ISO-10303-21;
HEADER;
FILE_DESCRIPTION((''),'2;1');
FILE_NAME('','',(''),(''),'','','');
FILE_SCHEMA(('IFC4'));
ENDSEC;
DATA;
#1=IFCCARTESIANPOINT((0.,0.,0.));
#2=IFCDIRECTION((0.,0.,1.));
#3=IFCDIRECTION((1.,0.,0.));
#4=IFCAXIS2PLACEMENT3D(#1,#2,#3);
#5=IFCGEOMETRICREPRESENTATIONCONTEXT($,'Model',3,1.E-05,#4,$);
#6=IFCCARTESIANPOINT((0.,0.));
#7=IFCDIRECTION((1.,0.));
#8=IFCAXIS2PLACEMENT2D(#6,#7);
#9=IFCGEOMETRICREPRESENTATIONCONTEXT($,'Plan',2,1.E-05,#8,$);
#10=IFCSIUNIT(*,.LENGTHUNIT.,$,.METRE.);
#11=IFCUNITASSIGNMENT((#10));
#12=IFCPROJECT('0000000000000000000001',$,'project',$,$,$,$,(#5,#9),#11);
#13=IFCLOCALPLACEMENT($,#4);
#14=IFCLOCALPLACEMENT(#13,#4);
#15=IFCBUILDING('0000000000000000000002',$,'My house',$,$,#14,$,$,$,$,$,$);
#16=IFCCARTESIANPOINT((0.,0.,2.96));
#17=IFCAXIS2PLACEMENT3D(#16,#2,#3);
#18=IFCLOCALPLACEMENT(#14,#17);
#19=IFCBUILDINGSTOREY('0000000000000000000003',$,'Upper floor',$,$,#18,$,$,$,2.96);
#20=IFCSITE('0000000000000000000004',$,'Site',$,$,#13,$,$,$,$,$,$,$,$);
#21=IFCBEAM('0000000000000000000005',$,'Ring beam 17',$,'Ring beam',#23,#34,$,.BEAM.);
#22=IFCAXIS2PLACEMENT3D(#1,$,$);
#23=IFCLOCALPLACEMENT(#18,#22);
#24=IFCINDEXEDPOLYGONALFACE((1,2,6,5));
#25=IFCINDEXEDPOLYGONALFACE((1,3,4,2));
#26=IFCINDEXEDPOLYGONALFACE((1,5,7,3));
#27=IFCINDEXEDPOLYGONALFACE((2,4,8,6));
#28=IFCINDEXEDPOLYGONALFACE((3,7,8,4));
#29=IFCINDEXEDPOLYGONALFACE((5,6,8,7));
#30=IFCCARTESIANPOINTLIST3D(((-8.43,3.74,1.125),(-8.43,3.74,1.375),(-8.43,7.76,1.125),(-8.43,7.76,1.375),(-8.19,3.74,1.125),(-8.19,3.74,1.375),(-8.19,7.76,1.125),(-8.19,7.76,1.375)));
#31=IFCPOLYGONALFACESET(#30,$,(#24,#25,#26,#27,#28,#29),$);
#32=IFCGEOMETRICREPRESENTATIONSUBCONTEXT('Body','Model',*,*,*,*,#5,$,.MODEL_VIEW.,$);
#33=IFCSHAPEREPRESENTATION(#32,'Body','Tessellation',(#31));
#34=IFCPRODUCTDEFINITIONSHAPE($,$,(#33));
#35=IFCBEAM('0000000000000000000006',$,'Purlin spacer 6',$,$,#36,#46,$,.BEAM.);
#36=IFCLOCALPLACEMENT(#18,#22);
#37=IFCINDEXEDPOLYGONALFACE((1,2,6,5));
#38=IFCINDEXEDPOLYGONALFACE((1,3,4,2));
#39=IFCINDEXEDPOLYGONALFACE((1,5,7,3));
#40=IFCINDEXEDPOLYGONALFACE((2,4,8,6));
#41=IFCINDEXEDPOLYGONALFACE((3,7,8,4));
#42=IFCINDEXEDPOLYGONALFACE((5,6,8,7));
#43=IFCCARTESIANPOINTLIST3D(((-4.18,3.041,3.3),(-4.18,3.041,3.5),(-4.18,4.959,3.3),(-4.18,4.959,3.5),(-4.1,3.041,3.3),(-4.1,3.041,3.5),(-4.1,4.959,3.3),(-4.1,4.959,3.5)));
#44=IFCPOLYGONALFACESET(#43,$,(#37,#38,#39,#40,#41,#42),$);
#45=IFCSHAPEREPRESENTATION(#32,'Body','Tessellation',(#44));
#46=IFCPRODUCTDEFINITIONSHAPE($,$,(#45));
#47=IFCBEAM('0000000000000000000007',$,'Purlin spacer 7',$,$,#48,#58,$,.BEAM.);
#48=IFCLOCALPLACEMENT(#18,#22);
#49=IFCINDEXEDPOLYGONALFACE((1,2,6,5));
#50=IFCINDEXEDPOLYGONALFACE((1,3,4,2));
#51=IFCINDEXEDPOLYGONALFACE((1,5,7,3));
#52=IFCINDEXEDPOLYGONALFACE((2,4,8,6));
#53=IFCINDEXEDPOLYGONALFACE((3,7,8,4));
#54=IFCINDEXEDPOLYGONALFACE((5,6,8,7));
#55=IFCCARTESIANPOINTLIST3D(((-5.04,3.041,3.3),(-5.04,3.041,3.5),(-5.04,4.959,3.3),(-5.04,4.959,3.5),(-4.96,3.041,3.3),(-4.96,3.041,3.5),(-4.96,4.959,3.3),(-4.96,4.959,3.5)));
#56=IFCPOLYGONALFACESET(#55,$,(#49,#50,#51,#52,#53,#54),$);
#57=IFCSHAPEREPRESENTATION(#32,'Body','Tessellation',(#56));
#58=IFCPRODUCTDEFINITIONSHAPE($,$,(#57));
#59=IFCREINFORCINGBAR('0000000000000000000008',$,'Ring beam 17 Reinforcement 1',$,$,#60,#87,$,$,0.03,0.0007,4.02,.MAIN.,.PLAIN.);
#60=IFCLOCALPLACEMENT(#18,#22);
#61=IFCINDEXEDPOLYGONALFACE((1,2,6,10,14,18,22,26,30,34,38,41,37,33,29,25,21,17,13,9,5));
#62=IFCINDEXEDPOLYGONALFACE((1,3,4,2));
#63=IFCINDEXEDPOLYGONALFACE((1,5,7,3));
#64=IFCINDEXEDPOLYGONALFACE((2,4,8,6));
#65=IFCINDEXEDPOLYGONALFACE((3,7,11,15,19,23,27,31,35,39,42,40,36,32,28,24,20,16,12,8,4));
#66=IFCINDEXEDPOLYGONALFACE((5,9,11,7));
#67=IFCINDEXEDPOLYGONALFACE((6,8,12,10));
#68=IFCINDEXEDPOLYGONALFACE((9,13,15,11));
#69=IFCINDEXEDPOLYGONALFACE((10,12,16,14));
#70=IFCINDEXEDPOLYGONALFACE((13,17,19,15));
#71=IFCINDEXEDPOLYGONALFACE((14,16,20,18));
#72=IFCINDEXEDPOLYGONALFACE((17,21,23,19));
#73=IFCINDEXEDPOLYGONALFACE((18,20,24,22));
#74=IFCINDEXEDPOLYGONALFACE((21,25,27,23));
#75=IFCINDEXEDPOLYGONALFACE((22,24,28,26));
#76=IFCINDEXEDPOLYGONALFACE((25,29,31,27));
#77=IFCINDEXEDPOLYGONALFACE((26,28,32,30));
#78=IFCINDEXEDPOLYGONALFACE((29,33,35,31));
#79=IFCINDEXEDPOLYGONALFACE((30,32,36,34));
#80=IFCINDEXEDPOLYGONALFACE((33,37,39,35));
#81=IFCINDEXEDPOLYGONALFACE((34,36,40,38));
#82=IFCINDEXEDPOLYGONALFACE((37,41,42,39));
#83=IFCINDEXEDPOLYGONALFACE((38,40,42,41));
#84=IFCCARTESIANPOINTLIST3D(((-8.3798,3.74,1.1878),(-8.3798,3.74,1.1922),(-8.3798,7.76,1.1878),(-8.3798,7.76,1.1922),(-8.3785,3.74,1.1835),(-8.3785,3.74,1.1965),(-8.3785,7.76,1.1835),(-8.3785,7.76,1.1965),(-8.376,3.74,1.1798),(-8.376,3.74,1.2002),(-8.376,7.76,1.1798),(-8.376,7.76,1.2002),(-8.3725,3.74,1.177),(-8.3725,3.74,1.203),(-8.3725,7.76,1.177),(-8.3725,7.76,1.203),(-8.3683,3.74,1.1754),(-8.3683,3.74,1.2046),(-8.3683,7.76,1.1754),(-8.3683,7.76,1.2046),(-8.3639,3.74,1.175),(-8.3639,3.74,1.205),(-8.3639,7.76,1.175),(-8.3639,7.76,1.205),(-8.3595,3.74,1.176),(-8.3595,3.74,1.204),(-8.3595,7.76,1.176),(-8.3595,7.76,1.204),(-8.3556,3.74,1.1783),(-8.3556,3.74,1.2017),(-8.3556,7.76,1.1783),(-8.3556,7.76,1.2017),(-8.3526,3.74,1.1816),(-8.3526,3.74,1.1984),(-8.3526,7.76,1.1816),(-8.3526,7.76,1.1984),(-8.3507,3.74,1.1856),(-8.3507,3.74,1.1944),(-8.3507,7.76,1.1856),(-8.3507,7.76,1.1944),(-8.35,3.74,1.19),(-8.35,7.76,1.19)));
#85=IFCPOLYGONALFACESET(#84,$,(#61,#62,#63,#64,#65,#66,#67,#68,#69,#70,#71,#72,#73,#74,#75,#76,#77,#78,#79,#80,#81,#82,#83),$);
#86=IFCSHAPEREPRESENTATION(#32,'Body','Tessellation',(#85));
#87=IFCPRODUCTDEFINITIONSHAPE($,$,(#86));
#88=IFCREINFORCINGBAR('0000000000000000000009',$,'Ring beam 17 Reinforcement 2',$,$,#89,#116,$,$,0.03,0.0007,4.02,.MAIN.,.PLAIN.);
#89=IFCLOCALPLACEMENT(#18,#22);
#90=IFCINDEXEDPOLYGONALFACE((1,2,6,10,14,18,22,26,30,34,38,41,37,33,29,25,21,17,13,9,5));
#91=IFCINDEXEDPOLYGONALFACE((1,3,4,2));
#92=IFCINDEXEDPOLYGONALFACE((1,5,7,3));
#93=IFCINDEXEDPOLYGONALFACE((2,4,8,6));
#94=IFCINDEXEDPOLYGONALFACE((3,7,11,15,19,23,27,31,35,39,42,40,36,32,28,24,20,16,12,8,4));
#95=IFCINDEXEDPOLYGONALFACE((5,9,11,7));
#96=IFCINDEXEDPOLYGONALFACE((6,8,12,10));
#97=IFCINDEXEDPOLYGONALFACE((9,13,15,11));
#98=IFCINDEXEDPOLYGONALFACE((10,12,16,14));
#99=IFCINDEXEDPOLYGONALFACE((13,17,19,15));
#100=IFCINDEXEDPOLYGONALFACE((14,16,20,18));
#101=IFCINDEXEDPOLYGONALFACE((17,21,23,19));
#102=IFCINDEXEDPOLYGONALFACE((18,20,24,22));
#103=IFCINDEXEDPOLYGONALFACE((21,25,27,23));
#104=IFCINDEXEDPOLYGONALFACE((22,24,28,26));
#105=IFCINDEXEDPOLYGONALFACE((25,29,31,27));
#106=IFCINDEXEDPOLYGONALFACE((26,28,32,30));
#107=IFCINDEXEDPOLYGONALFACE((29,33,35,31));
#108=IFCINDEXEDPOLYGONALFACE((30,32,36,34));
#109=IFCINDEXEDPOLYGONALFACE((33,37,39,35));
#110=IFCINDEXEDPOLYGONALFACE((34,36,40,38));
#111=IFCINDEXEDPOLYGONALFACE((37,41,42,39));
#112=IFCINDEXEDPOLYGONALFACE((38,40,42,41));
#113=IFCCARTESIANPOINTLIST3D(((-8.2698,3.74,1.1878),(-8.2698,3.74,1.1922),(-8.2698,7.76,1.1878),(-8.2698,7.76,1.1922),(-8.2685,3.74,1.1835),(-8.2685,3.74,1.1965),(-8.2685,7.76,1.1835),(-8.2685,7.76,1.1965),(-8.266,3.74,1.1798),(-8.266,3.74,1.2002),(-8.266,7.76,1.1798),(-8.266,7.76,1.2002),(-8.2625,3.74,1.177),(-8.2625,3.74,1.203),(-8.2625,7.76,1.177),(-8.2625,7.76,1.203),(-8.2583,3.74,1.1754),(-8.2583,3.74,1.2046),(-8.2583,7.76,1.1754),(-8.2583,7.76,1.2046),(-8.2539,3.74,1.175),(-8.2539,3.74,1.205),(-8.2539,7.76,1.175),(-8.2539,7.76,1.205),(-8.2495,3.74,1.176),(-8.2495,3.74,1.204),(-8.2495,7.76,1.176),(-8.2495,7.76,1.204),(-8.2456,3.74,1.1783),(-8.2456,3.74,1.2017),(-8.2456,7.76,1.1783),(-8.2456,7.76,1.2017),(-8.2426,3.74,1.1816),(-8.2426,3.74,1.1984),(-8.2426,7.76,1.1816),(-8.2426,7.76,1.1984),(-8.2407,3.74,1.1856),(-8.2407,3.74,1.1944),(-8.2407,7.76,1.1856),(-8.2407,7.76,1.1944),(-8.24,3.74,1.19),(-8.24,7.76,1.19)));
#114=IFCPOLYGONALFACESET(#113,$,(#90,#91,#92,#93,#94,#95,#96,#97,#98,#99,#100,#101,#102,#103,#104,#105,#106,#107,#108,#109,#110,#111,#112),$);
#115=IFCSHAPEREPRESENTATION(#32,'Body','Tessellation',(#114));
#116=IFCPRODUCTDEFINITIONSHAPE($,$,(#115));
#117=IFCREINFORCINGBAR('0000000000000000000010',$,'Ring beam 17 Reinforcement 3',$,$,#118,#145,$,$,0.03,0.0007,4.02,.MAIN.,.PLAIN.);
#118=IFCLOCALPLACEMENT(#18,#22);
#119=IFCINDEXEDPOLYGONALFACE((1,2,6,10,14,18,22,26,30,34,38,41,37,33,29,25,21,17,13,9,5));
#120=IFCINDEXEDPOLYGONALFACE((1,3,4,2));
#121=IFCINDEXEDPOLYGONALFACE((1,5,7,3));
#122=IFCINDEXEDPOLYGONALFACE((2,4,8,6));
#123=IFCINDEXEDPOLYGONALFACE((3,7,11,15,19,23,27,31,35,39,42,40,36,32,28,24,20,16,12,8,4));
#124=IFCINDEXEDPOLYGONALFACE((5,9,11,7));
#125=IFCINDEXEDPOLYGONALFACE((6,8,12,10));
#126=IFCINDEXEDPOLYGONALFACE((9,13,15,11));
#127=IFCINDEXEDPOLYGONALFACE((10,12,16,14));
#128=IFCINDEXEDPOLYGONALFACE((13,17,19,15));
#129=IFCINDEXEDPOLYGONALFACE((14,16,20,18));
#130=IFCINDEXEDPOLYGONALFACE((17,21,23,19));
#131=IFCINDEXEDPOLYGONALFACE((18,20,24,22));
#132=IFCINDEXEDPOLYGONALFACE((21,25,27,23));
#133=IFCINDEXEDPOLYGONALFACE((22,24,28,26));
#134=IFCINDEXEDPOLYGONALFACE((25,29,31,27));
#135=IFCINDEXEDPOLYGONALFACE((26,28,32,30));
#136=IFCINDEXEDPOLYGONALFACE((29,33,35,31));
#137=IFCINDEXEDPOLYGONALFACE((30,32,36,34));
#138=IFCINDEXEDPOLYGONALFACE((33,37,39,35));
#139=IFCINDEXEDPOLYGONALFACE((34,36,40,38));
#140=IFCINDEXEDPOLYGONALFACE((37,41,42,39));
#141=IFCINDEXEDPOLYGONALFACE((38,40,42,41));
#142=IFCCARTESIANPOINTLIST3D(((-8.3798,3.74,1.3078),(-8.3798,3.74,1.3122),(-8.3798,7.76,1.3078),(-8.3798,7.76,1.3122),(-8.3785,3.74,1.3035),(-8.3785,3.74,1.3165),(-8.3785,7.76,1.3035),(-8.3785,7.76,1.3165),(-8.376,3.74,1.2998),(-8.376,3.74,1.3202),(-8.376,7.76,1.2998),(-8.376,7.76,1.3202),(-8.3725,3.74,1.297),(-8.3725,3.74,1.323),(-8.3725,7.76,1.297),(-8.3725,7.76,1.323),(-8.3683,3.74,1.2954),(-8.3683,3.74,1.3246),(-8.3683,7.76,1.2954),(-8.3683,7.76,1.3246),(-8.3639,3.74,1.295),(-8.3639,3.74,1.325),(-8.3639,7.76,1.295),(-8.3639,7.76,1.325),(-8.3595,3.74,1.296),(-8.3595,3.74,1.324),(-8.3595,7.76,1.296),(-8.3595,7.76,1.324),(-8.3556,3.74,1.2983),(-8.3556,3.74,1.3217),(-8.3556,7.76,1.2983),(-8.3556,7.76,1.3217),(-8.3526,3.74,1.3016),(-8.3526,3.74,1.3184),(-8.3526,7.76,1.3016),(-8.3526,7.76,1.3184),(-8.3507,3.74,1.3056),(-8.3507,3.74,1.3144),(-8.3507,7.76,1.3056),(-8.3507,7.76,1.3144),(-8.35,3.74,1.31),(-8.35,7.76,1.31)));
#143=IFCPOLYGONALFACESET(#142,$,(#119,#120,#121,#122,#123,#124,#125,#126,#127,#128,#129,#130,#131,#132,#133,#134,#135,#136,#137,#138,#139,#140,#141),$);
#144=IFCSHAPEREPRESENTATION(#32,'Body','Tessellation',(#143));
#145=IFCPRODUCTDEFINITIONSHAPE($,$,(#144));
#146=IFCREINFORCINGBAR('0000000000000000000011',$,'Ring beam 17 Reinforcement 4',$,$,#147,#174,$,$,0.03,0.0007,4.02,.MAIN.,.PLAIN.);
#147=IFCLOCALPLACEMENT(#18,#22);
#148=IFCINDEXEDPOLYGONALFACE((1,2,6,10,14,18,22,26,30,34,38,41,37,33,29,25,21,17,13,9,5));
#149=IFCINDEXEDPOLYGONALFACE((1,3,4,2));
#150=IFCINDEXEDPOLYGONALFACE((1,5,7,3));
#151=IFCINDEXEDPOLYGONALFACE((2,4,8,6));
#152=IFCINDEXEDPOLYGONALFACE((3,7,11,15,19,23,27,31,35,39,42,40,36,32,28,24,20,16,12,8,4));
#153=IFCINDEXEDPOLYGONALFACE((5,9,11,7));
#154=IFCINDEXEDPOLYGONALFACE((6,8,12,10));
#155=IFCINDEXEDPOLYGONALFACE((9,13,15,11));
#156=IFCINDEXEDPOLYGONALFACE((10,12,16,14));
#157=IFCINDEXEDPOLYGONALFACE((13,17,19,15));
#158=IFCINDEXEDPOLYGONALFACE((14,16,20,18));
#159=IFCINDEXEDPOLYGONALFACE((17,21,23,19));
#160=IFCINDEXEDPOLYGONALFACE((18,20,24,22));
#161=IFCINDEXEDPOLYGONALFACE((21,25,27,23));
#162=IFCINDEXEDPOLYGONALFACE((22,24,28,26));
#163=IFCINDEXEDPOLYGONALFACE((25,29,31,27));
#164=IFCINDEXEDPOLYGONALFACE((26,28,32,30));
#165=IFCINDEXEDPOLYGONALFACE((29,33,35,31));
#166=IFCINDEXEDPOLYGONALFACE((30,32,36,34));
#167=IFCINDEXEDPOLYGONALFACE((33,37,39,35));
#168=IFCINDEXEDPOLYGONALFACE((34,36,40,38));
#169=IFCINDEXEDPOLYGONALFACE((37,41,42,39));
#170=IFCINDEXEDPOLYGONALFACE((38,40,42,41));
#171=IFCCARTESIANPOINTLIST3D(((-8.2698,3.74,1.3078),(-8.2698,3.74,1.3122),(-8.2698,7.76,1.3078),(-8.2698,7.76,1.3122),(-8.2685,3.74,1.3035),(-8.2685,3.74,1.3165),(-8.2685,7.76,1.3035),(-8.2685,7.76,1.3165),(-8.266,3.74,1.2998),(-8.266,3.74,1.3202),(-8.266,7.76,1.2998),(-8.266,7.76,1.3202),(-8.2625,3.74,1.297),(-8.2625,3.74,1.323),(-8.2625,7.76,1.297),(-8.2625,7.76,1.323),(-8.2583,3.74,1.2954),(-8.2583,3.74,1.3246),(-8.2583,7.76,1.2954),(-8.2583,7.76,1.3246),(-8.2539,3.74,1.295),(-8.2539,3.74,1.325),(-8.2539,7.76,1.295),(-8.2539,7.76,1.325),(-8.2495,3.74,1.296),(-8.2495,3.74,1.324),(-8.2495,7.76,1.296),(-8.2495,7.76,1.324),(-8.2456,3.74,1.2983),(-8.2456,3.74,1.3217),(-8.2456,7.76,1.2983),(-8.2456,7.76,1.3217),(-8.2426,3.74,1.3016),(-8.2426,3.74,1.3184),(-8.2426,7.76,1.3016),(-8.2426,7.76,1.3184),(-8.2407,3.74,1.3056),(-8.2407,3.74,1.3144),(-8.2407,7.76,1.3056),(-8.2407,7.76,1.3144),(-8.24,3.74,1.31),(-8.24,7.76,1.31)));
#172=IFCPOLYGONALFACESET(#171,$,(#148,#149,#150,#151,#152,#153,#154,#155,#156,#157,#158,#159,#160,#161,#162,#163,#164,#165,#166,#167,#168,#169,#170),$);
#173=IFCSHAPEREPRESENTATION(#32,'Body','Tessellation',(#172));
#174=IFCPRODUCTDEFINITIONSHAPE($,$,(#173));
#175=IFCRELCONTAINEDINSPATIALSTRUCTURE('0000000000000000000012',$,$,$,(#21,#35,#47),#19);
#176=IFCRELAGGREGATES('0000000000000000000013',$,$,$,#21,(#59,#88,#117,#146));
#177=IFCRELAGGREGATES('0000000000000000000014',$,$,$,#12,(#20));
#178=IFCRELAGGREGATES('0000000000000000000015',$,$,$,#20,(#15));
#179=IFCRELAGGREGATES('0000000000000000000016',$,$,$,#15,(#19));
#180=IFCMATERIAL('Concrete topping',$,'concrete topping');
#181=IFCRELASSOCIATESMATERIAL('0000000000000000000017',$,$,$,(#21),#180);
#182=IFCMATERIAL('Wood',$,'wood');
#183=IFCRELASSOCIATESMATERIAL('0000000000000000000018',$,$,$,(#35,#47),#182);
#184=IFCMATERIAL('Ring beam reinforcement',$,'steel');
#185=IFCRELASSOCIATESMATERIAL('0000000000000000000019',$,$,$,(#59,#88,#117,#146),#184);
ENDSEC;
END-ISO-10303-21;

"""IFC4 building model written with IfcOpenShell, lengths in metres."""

from ifc_helpers import new_model, si_unit, frame, origin_with_axes, origin_2d, origin_2d_with_axis, place, context, subcontext, project, spatial, circle_curve, rectangle, outline, extrude, source, transform, mapped, material, element, aggregate, save


model = new_model("IFC4")

# Units and contexts
model_context = context("Model", 3, precision=1e-05, world=origin_with_axes())
plan_context = context("Plan", 2, precision=1e-05, world=origin_2d_with_axis())
body_context_1 = subcontext(model_context, "Body", "Model", "MODEL_VIEW")
ifc_project = project(units=[si_unit("LENGTHUNIT", "METRE")], contexts=[model_context, plan_context])

# Site, building, storey
site_placement = place(None, origin_with_axes())
site = spatial("IfcSite", under=ifc_project, at=site_placement, Name="Site")
building_placement = place(site_placement, origin_with_axes())
building = spatial("IfcBuilding", under=site, at=building_placement, Name="My house")
storey_placement = place(building_placement, frame((0.0, 0.0, 2.96), z_axis=(0.0, 0.0, 1.0), x_axis=(1.0, 0.0, 0.0)))
storey = spatial("IfcBuildingStorey", under=building, at=storey_placement, Name="Upper floor", Elevation=2.96)

# Shared definitions
ifc_material_1 = material(Name="Concrete topping", Category="concrete topping")

# Shared definitions
ifc_material_2 = material(Name="Wood", Category="wood")

# Beam
shared_shape_1 = source(origin_with_axes(), body_context_1, "Body", "SweptSolid", [
    extrude(rectangle(XDim=0.24, YDim=0.25), frame((0.0, 0.0, 0.0), z_axis=(1.0, 0.0, 0.0), x_axis=(0.0, 1.0, 0.0)), (0.0, 0.0, 1.0), 4.02),
])
beam_1_placement = place(storey_placement, frame((-8.31, 3.74, 1.25), z_axis=(0.0, 0.0, 1.0), x_axis=(0.0, -1.0, 0.0)))
beam_1 = element("IfcBeam", 1, at=beam_1_placement, inside=storey, material=ifc_material_1, Name="Ring beam 17", ObjectType="Ring beam", PredefinedType="BEAM", context=body_context_1, shape_type="MappedRepresentation", body=[
    mapped(shared_shape_1, transform((0.0, 0.0, 0.0), x_axis=(-1.0, 0.0, 0.0), y_axis=(0.0, 1.0, 0.0), z_axis=(0.0, 0.0, 1.0), scale=1.0)),
])

# Beams
shared_shape_2 = source(origin_with_axes(), body_context_1, "Body", "SweptSolid", [
    extrude(rectangle(XDim=0.08, YDim=0.2), frame((0.0, 0.0, 0.0), z_axis=(1.0, 0.0, 0.0), x_axis=(0.0, 1.0, 0.0)), (0.0, 0.0, 1.0), 1.918),
])
beam_2_placement = place(storey_placement, frame((-4.14, 3.041, 3.4), z_axis=(0.0, 0.0, 1.0), x_axis=(0.0, -1.0, 0.0)))
element("IfcBeam", 2, at=beam_2_placement, inside=storey, material=ifc_material_2, Name="Purlin spacer 6", PredefinedType="BEAM", context=body_context_1, shape_type="MappedRepresentation", body=[
    mapped(shared_shape_2, transform((0.0, 0.0, 0.0), x_axis=(-1.0, 0.0, 0.0), y_axis=(0.0, 1.0, 0.0), z_axis=(0.0, 0.0, 1.0), scale=1.0)),
])
shared_shape_3 = source(origin_with_axes(), body_context_1, "Body", "SweptSolid", [
    extrude(rectangle(XDim=0.08, YDim=0.2), frame((0.0, 0.0, 0.0), z_axis=(1.0, 0.0, 0.0), x_axis=(0.0, 1.0, 0.0)), (0.0, 0.0, 1.0), 1.918),
])
beam_3_placement = place(storey_placement, frame((-5.0, 3.041, 3.4), z_axis=(0.0, 0.0, 1.0), x_axis=(0.0, -1.0, 0.0)))
element("IfcBeam", 3, at=beam_3_placement, inside=storey, material=ifc_material_2, Name="Purlin spacer 7", PredefinedType="BEAM", context=body_context_1, shape_type="MappedRepresentation", body=[
    mapped(shared_shape_3, transform((0.0, 0.0, 0.0), x_axis=(-1.0, 0.0, 0.0), y_axis=(0.0, 1.0, 0.0), z_axis=(0.0, 0.0, 1.0), scale=1.0)),
])

# Reinforcing bars
ifc_material_3 = material(Name="Ring beam reinforcement", Category="steel")
shared_shape_4 = source(origin_with_axes(), body_context_1, "Body", "SweptSolid", [
    extrude(outline(circle_curve(origin_2d(), 0.015)), frame((0.0, 0.0, 0.0), z_axis=(1.0, 0.0, 0.0), x_axis=(0.0, 1.0, 0.0)), (0.0, 0.0, 1.0), 4.02),
])
reinforcing_bar_1_placement = place(beam_1_placement, frame((0.0, -0.055, -0.06), z_axis=(0.0, 0.0, 1.0), x_axis=(1.0, 0.0, 0.0)))
reinforcing_bar_1 = element("IfcReinforcingBar", 4, at=reinforcing_bar_1_placement, material=ifc_material_3, Name="Ring beam 17 Reinforcement 1", BarLength=4.02, BarSurface="PLAIN", CrossSectionArea=0.0007, NominalDiameter=0.03, PredefinedType="MAIN", context=body_context_1, shape_type="MappedRepresentation", body=[
    mapped(shared_shape_4, transform((0.0, 0.0, 0.0), x_axis=(-1.0, 0.0, 0.0), y_axis=(0.0, 1.0, 0.0), z_axis=(0.0, 0.0, 1.0), scale=1.0)),
])
shared_shape_5 = source(origin_with_axes(), body_context_1, "Body", "SweptSolid", [
    extrude(outline(circle_curve(origin_2d(), 0.015)), frame((0.0, 0.0, 0.0), z_axis=(1.0, 0.0, 0.0), x_axis=(0.0, 1.0, 0.0)), (0.0, 0.0, 1.0), 4.02),
])
reinforcing_bar_2_placement = place(beam_1_placement, frame((0.0, 0.055, -0.06), z_axis=(0.0, 0.0, 1.0), x_axis=(1.0, 0.0, 0.0)))
reinforcing_bar_2 = element("IfcReinforcingBar", 5, at=reinforcing_bar_2_placement, material=ifc_material_3, Name="Ring beam 17 Reinforcement 2", BarLength=4.02, BarSurface="PLAIN", CrossSectionArea=0.0007, NominalDiameter=0.03, PredefinedType="MAIN", context=body_context_1, shape_type="MappedRepresentation", body=[
    mapped(shared_shape_5, transform((0.0, 0.0, 0.0), x_axis=(-1.0, 0.0, 0.0), y_axis=(0.0, 1.0, 0.0), z_axis=(0.0, 0.0, 1.0), scale=1.0)),
])
shared_shape_6 = source(origin_with_axes(), body_context_1, "Body", "SweptSolid", [
    extrude(outline(circle_curve(origin_2d(), 0.015)), frame((0.0, 0.0, 0.0), z_axis=(1.0, 0.0, 0.0), x_axis=(0.0, 1.0, 0.0)), (0.0, 0.0, 1.0), 4.02),
])
reinforcing_bar_3_placement = place(beam_1_placement, frame((0.0, -0.055, 0.06), z_axis=(0.0, 0.0, 1.0), x_axis=(1.0, 0.0, 0.0)))
reinforcing_bar_3 = element("IfcReinforcingBar", 6, at=reinforcing_bar_3_placement, material=ifc_material_3, Name="Ring beam 17 Reinforcement 3", BarLength=4.02, BarSurface="PLAIN", CrossSectionArea=0.0007, NominalDiameter=0.03, PredefinedType="MAIN", context=body_context_1, shape_type="MappedRepresentation", body=[
    mapped(shared_shape_6, transform((0.0, 0.0, 0.0), x_axis=(-1.0, 0.0, 0.0), y_axis=(0.0, 1.0, 0.0), z_axis=(0.0, 0.0, 1.0), scale=1.0)),
])
shared_shape_7 = source(origin_with_axes(), body_context_1, "Body", "SweptSolid", [
    extrude(outline(circle_curve(origin_2d(), 0.015)), frame((0.0, 0.0, 0.0), z_axis=(1.0, 0.0, 0.0), x_axis=(0.0, 1.0, 0.0)), (0.0, 0.0, 1.0), 4.02),
])
reinforcing_bar_4_placement = place(beam_1_placement, frame((0.0, 0.055, 0.06), z_axis=(0.0, 0.0, 1.0), x_axis=(1.0, 0.0, 0.0)))
reinforcing_bar_4 = element("IfcReinforcingBar", 7, at=reinforcing_bar_4_placement, material=ifc_material_3, Name="Ring beam 17 Reinforcement 4", BarLength=4.02, BarSurface="PLAIN", CrossSectionArea=0.0007, NominalDiameter=0.03, PredefinedType="MAIN", context=body_context_1, shape_type="MappedRepresentation", body=[
    mapped(shared_shape_7, transform((0.0, 0.0, 0.0), x_axis=(-1.0, 0.0, 0.0), y_axis=(0.0, 1.0, 0.0), z_axis=(0.0, 0.0, 1.0), scale=1.0)),
])
aggregate(beam_1, [reinforcing_bar_1, reinforcing_bar_2, reinforcing_bar_3, reinforcing_bar_4])

save(model, "model.ifc")
